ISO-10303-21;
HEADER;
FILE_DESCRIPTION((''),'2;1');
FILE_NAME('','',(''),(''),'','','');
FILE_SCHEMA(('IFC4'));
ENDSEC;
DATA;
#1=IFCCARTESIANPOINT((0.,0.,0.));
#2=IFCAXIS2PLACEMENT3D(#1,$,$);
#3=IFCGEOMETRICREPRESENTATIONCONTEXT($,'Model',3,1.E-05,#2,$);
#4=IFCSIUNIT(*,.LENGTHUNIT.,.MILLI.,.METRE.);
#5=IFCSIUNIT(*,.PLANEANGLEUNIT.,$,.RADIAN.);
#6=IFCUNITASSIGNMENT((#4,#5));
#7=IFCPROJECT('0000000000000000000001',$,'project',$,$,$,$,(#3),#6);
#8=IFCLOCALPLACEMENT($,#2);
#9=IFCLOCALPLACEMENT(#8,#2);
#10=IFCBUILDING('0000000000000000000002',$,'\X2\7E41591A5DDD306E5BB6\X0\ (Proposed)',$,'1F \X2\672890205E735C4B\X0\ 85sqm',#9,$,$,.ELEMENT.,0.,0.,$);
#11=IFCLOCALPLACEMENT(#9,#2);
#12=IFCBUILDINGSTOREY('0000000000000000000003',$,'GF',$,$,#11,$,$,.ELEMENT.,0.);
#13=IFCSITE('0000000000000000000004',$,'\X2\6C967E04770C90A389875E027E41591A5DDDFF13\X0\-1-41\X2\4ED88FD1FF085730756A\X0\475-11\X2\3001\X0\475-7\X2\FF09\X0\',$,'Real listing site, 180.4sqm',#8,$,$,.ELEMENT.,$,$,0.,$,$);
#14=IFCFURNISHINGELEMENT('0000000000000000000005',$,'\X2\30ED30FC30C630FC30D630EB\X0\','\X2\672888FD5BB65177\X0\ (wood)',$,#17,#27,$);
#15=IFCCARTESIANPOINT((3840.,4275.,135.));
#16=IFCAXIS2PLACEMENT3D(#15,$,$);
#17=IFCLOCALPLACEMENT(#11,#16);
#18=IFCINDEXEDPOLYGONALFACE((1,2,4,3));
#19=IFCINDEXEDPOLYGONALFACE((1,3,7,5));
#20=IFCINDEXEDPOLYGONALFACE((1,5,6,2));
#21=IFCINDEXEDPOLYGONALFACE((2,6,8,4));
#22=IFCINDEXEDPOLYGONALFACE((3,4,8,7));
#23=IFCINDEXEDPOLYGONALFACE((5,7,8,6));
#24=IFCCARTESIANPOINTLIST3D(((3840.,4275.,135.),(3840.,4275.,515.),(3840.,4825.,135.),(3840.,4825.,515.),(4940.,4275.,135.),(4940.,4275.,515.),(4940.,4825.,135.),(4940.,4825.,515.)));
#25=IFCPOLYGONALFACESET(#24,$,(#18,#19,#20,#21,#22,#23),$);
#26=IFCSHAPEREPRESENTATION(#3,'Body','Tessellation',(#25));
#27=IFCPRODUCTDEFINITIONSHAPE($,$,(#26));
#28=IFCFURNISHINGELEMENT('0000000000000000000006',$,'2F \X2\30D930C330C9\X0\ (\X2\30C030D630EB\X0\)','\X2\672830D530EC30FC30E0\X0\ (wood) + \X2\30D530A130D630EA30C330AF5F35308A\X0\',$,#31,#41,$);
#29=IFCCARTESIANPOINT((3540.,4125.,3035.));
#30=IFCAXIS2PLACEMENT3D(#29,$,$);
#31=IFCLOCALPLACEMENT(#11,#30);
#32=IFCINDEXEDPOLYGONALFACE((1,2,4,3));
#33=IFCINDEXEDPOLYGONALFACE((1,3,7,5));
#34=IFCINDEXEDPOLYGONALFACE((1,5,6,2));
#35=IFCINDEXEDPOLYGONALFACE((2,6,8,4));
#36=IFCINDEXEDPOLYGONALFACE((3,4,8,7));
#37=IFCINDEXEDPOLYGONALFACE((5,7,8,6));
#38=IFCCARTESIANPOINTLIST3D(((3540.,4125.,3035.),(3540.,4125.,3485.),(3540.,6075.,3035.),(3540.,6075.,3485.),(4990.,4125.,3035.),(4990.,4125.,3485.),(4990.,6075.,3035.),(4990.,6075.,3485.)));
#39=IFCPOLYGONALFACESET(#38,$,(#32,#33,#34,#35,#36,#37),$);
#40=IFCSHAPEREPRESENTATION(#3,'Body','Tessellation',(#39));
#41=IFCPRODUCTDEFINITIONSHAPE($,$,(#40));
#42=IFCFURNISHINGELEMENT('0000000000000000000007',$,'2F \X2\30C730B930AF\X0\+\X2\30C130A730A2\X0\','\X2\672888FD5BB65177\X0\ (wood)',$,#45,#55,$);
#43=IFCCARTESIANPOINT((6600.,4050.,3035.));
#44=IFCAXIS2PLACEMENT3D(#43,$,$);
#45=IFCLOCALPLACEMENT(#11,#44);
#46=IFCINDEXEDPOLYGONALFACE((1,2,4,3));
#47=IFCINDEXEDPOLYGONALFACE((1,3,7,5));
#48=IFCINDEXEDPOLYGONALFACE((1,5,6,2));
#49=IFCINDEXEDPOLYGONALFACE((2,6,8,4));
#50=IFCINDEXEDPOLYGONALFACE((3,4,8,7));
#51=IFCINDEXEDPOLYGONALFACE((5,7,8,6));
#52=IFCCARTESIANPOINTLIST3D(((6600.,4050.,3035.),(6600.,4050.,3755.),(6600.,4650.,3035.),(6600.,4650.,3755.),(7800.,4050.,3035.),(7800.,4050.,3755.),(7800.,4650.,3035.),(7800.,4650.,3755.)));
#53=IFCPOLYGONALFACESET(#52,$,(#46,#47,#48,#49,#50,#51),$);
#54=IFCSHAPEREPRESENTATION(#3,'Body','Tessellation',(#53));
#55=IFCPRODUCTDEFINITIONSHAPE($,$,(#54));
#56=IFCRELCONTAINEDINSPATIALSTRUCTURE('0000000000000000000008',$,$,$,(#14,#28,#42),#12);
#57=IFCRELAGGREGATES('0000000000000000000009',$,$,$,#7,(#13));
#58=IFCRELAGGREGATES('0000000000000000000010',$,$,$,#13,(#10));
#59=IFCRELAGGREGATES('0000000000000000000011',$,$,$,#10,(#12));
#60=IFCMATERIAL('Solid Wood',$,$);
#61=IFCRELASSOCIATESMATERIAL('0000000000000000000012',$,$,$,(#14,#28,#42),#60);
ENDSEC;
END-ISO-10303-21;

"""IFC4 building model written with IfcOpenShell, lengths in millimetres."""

from ifc_helpers import new_model, si_unit, frame, frame_2d, origin, place, context, project, spatial, rectangle, extrude, material, element, save


model = new_model("IFC4")

# Units and contexts
model_context = context("Model", 3, precision=1e-05, world=origin())
ifc_project = project(units=[si_unit("LENGTHUNIT", "METRE", prefix="MILLI"), si_unit("PLANEANGLEUNIT", "RADIAN")], contexts=[model_context])

# Site, building, storey
site_placement = place(None, origin())
site = spatial("IfcSite", under=ifc_project, at=site_placement, Name="沖縄県那覇市繁多川３-1-41付近（地番475-11、475-7）", ObjectType="Real listing site, 180.4sqm", CompositionType="ELEMENT", RefElevation=0.0)
building_placement = place(site_placement, origin())
building = spatial("IfcBuilding", under=site, at=building_placement, Name="繁多川の家 (Proposed)", ObjectType="1F 木造平屋 85sqm", CompositionType="ELEMENT", ElevationOfRefHeight=0.0, ElevationOfTerrain=0.0)
storey_placement = place(building_placement, origin())
storey = spatial("IfcBuildingStorey", under=building, at=storey_placement, Name="GF", CompositionType="ELEMENT", Elevation=0.0)

# Shared definitions
ifc_material_1 = material(Name="Solid Wood")

# Furnishing elements
furnishing_1_placement = place(storey_placement, frame((3840.0, 4275.0, 135.0)))
element("IfcFurnishingElement", 1, at=furnishing_1_placement, inside=storey, material=ifc_material_1, Name="ローテーブル", Description="木製家具 (wood)", context=model_context, shape_type="SweptSolid", body=[
    extrude(rectangle(XDim=1100.0, YDim=550.0, at=frame_2d((550.0, 275.0))), frame((3840.0, 4275.0, 135.0)), (0.0, 0.0, 1.0), 380.0),
])
furnishing_2_placement = place(storey_placement, frame((3540.0, 4125.0, 3035.0)))
element("IfcFurnishingElement", 2, at=furnishing_2_placement, inside=storey, material=ifc_material_1, Name="2F ベッド (ダブル)", Description="木フレーム (wood) + ファブリック張り", context=model_context, shape_type="SweptSolid", body=[
    extrude(rectangle(XDim=1450.0, YDim=1950.0, at=frame_2d((725.0, 975.0))), frame((3540.0, 4125.0, 3035.0)), (0.0, 0.0, 1.0), 450.0),
])
furnishing_3_placement = place(storey_placement, frame((6600.0, 4050.0, 3035.0)))
element("IfcFurnishingElement", 3, at=furnishing_3_placement, inside=storey, material=ifc_material_1, Name="2F デスク+チェア", Description="木製家具 (wood)", context=model_context, shape_type="SweptSolid", body=[
    extrude(rectangle(XDim=1200.0, YDim=600.0, at=frame_2d((600.0, 300.0))), frame((6600.0, 4050.0, 3035.0)), (0.0, 0.0, 1.0), 720.0),
])

save(model, "model.ifc")
